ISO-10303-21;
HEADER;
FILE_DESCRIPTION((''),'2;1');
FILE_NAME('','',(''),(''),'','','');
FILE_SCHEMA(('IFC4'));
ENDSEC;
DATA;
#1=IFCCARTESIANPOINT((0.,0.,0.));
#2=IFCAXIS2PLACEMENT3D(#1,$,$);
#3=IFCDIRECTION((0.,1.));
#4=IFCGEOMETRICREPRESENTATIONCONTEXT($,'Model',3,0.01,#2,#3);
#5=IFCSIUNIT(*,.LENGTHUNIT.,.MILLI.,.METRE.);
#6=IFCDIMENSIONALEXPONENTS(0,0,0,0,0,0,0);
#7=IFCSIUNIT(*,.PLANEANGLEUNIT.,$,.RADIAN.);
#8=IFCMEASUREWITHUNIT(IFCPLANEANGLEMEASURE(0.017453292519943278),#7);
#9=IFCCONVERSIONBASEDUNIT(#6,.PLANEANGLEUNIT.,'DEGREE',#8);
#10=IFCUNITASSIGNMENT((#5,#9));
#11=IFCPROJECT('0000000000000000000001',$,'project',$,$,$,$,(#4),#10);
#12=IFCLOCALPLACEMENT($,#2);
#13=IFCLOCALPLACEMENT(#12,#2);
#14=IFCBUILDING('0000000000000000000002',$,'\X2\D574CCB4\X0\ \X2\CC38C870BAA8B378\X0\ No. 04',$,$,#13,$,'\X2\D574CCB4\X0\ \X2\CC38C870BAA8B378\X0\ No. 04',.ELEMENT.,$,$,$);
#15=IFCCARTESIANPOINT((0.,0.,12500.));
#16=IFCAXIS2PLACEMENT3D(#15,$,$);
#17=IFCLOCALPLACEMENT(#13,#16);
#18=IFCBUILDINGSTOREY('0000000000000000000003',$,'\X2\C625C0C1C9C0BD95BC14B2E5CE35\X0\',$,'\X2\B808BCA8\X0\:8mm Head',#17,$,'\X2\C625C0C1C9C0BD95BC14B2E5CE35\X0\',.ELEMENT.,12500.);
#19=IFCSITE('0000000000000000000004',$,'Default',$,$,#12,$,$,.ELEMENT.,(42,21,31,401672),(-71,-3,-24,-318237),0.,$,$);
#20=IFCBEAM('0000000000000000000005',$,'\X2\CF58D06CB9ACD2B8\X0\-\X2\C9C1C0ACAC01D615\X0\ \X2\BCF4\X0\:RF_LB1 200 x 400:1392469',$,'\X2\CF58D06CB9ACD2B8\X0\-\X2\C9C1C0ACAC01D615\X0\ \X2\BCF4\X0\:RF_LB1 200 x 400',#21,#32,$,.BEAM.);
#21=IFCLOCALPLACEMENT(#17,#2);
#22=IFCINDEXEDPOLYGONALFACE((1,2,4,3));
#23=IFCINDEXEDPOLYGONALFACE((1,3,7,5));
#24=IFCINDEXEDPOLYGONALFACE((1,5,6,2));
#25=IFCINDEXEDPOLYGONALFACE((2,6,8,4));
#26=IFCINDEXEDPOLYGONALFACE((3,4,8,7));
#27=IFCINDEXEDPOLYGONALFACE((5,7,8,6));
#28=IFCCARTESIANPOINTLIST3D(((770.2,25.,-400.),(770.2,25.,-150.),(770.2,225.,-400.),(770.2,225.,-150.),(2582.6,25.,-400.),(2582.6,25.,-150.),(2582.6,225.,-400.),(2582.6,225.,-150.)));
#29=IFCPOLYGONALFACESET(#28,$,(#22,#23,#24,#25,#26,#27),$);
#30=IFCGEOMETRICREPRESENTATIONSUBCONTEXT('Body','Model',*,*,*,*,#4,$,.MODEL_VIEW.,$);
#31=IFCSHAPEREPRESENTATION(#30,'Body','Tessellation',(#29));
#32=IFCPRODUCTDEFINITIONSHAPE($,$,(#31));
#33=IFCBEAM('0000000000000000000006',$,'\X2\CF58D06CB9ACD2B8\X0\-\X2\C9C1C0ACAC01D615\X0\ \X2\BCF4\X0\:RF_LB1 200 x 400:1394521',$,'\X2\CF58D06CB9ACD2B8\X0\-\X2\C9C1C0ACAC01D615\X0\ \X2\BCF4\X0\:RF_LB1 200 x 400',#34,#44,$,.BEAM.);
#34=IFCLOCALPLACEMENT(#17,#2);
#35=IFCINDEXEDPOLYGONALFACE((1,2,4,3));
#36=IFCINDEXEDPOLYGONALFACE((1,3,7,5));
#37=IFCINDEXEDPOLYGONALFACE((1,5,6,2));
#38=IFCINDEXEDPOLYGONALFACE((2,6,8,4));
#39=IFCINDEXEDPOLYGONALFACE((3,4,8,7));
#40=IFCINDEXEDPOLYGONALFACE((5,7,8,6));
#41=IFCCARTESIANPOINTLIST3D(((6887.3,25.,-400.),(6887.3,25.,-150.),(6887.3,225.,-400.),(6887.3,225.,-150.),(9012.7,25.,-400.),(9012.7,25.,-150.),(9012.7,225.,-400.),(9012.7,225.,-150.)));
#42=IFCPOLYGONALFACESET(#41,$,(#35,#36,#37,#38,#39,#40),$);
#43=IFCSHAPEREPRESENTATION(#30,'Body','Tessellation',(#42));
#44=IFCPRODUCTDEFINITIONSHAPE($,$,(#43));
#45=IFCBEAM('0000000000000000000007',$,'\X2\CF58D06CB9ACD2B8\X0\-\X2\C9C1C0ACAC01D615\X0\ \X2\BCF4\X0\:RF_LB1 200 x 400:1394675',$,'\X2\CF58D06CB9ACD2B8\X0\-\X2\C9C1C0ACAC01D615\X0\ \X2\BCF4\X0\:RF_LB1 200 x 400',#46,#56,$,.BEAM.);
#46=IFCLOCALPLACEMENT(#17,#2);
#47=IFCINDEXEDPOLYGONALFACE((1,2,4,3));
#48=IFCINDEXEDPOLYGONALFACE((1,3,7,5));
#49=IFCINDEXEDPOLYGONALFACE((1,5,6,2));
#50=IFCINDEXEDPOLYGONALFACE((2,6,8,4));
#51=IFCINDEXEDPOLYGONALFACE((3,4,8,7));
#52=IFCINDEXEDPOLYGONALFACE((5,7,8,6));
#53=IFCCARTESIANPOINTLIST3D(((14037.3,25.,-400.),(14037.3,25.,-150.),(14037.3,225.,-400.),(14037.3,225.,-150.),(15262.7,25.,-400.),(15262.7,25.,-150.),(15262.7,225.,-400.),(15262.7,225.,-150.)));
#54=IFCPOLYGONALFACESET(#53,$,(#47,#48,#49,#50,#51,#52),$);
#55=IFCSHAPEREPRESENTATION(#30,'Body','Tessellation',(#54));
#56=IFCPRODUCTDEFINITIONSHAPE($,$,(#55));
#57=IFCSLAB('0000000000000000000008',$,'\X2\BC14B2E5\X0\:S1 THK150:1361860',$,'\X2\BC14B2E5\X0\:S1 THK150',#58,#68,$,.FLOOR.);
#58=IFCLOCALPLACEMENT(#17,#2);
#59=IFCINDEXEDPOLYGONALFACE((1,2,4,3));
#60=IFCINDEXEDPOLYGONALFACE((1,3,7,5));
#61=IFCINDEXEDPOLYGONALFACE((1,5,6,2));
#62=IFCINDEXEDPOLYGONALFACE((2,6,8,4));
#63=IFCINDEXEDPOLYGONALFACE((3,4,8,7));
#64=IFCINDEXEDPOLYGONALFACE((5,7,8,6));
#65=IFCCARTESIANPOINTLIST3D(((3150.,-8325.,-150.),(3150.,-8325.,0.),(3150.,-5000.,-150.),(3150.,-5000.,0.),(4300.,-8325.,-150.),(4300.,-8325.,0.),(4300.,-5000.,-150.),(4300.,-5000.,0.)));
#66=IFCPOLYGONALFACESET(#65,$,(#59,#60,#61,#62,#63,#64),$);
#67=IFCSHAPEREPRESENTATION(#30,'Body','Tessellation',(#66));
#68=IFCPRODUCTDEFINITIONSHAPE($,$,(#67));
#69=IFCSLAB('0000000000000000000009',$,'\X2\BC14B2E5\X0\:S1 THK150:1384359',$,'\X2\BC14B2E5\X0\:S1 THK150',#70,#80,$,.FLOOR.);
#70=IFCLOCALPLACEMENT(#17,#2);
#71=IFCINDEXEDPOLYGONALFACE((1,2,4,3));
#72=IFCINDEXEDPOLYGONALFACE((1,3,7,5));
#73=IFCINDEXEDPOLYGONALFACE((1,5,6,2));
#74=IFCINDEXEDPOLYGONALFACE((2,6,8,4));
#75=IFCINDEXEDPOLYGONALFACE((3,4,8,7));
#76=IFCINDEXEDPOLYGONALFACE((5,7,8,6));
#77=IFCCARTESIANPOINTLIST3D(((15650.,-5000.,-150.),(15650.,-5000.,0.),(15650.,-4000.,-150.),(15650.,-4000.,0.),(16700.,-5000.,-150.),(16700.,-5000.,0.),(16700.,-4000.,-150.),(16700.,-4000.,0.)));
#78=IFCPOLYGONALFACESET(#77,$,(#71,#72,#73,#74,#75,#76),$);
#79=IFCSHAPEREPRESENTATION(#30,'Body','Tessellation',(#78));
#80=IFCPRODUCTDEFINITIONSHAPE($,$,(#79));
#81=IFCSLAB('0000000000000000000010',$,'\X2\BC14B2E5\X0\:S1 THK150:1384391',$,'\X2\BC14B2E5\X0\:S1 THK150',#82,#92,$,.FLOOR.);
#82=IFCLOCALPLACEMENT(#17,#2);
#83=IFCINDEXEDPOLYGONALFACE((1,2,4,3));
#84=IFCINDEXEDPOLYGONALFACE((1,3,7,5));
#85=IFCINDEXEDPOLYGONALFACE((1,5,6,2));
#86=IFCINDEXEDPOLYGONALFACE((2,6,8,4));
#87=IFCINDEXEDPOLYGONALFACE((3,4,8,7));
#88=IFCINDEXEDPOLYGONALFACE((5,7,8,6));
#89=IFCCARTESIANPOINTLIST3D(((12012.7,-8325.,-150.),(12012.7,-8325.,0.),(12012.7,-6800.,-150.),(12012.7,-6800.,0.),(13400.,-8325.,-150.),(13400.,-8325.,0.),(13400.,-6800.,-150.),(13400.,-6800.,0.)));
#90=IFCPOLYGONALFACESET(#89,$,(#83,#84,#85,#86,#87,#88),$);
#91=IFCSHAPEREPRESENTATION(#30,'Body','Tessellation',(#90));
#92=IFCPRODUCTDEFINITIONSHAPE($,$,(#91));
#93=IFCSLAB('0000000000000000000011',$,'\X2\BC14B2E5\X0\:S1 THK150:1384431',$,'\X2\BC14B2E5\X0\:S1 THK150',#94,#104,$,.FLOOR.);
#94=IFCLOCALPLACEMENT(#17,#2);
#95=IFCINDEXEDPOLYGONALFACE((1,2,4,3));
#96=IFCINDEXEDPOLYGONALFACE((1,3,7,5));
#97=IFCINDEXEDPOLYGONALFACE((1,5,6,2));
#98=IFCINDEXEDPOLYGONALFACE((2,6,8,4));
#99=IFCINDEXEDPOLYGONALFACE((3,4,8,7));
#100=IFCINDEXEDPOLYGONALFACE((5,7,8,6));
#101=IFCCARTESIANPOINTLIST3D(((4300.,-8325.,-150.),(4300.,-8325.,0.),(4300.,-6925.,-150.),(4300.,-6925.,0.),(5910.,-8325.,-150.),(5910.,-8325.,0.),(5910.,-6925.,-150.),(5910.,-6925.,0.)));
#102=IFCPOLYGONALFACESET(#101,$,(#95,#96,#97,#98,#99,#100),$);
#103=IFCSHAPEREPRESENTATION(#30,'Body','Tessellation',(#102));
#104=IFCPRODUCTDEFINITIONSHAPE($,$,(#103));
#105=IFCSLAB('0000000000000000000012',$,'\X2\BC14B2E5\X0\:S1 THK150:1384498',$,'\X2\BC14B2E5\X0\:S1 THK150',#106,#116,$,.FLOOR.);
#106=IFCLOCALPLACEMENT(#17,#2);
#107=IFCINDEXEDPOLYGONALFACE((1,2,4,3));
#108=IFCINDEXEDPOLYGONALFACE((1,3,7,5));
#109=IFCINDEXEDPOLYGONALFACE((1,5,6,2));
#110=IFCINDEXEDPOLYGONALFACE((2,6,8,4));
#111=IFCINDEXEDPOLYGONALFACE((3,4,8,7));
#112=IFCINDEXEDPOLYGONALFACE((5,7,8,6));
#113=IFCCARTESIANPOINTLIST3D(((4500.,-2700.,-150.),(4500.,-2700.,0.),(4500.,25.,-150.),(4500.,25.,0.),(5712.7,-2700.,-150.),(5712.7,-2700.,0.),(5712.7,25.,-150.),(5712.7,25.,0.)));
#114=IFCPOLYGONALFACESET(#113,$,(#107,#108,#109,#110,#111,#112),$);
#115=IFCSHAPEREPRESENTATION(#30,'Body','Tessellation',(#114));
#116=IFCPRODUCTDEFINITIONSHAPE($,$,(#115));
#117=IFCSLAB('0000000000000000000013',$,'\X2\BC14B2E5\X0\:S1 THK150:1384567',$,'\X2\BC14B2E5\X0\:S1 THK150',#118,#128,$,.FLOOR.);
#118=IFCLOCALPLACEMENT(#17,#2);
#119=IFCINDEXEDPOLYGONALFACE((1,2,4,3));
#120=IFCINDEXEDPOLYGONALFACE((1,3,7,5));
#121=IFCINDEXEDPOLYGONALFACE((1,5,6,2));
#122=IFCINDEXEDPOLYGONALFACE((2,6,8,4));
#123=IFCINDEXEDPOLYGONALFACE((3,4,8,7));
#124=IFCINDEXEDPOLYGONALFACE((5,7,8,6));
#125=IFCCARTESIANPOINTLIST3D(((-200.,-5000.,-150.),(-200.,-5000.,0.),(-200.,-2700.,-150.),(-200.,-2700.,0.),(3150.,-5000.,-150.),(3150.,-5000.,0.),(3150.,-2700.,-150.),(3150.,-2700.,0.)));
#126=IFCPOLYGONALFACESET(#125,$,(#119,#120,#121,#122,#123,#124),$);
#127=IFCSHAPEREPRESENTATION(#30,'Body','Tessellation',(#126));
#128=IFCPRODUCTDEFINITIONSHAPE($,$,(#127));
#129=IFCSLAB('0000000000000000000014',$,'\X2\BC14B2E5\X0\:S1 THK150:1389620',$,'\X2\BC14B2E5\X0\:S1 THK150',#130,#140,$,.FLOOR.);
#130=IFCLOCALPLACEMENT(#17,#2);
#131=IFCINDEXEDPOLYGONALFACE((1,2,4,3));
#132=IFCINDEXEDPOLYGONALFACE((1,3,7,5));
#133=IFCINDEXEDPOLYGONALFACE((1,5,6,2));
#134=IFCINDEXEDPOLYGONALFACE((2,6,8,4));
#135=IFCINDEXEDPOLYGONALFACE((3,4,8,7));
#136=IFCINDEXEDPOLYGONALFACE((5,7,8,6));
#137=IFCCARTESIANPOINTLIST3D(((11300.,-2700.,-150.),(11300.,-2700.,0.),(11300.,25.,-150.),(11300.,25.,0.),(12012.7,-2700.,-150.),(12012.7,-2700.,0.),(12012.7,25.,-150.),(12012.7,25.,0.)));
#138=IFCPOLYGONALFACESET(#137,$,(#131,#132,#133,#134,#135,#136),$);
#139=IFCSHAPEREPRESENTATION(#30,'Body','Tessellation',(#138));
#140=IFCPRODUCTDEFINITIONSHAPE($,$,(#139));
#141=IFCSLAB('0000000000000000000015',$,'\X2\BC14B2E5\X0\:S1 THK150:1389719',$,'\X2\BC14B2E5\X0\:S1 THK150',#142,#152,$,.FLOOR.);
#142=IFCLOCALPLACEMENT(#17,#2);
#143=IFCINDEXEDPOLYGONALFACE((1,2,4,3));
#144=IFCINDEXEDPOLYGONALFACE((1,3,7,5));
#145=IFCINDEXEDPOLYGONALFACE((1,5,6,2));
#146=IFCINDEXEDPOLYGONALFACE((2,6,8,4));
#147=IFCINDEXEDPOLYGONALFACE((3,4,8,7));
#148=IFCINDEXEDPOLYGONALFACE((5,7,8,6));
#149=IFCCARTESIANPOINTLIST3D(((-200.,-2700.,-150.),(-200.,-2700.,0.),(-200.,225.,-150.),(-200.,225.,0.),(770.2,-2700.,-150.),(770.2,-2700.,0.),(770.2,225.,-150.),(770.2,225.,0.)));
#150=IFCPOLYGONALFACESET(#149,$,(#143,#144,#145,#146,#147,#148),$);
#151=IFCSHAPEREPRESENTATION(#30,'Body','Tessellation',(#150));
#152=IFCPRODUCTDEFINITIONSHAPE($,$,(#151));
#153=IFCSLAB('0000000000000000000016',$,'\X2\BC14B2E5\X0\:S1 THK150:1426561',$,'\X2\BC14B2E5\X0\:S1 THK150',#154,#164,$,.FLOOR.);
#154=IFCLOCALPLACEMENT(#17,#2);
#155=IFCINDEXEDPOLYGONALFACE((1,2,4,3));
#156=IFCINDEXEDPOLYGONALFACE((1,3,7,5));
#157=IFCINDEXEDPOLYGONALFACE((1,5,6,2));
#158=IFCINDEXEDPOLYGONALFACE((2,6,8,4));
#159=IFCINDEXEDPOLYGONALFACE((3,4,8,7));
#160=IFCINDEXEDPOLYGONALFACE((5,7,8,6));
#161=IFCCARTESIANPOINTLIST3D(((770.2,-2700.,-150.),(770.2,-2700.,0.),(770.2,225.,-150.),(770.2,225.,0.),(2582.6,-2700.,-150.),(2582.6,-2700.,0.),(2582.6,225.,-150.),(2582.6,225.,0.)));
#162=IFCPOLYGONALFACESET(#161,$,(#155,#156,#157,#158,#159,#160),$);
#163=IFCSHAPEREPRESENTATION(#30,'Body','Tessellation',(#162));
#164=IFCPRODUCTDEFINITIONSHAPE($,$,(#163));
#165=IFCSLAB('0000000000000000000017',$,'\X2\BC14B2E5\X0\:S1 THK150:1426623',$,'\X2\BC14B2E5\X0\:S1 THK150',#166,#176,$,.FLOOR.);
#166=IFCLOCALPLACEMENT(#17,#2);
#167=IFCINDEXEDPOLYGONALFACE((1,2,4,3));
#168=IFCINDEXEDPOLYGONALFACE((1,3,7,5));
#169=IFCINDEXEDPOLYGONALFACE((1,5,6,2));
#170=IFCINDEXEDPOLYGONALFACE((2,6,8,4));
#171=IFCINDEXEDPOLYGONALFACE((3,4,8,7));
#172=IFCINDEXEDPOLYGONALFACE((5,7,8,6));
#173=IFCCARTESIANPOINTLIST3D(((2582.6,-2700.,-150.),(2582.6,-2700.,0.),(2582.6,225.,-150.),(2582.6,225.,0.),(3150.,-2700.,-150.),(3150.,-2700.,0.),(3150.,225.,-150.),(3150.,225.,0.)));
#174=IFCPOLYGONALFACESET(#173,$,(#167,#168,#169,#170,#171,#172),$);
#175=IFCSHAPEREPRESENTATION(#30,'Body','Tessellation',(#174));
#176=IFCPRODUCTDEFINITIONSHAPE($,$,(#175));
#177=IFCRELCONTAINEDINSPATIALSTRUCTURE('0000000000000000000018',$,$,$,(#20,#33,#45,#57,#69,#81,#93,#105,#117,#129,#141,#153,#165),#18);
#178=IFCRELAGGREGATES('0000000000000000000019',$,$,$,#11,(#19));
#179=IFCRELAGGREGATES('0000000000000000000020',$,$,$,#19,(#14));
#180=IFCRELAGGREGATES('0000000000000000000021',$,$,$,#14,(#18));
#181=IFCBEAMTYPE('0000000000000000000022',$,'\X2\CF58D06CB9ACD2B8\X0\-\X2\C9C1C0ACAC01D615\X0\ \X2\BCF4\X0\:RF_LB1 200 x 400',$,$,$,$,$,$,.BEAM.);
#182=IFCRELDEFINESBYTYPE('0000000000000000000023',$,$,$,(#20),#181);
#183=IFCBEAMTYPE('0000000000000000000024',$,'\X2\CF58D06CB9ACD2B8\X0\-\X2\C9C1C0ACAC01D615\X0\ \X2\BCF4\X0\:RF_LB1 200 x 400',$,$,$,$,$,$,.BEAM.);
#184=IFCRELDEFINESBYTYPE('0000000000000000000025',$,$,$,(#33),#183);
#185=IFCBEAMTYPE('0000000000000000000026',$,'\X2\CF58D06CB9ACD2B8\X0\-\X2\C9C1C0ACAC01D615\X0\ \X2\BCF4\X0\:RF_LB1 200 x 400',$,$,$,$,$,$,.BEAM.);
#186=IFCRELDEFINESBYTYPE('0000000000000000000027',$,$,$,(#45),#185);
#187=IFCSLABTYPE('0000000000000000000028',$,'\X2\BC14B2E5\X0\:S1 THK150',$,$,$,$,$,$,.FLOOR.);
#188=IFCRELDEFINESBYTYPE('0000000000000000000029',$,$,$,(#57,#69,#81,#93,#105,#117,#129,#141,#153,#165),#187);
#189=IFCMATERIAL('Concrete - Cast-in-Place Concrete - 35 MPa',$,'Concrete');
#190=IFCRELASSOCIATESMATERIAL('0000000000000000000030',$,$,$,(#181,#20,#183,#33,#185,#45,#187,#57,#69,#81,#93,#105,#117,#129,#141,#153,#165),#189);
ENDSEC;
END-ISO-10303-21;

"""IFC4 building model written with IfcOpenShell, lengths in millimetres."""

from ifc_helpers import new_model, entity, si_unit, converted_unit, direction, frame, origin, place, context, subcontext, project, spatial, indexed_curve, outline, extrude, source, transform, mapped, material, type_object, type_shapes, element, save


model = new_model("IFC4")

# Units and contexts
model_context = context("Model", 3, precision=0.01, world=origin(), true_north=direction((0.0, 1.0)))
body_context = subcontext(model_context, "Body", "Model", "MODEL_VIEW")
ifc_project = project(units=[si_unit("LENGTHUNIT", "METRE", prefix="MILLI"), converted_unit("PLANEANGLEUNIT", "DEGREE", entity("IfcPlaneAngleMeasure", 0.017453292519943278), si_unit("PLANEANGLEUNIT", "RADIAN"), dimensions=[0, 0, 0, 0, 0, 0, 0])], contexts=[model_context])

# Site, building, storey
site_placement = place(None, origin())
site = spatial("IfcSite", under=ifc_project, at=site_placement, Name="Default", CompositionType="ELEMENT", RefLatitude=(42, 21, 31, 401672), RefLongitude=(-71, -3, -24, -318237), RefElevation=0.0)
building_placement = place(site_placement, origin())
building = spatial("IfcBuilding", under=site, at=building_placement, Name="해체 참조모델 No. 04", LongName="해체 참조모델 No. 04", CompositionType="ELEMENT")
storey_placement = place(building_placement, frame((0.0, 0.0, 12500.0)))
storey = spatial("IfcBuildingStorey", under=building, at=storey_placement, Name="옥상지붕바닥층", ObjectType="레벨:8mm Head", LongName="옥상지붕바닥층", CompositionType="ELEMENT", Elevation=12500.0)

# Beams
ifc_material_1 = material(Name="Concrete - Cast-in-Place Concrete - 35 MPa", Category="Concrete")
beam_type_1 = type_object("IfcBeamType", Name="콘크리트-직사각형 보:RF_LB1 200 x 400", PredefinedType="BEAM", material=ifc_material_1)
shared_shape_1 = source(origin(), body_context, "Body", "SweptSolid", [
    extrude(outline(indexed_curve([(-125.0, -100.0), (125.0, -100.0), (125.0, 100.0), (-125.0, 100.0), (-125.0, -100.0)], self_intersect=False)), frame((770.2, 125.0, 12225.0), z_axis=(1.0, 0.0, 0.0), x_axis=(0.0, 0.0, -1.0)), (0.0, 0.0, 1.0), 1812.4),
])
type_shapes(beam_type_1, [shared_shape_1])
beam_1_placement = place(storey_placement, frame((0.0, 0.0, -12500.0)))
element("IfcBeam", 1, at=beam_1_placement, inside=storey, type_object=beam_type_1, material=ifc_material_1, Name="콘크리트-직사각형 보:RF_LB1 200 x 400:1392469", ObjectType="콘크리트-직사각형 보:RF_LB1 200 x 400", PredefinedType="BEAM", context=body_context, shape_type="MappedRepresentation", body=[
    mapped(shared_shape_1, transform((0.0, 0.0, 0.0), scale=1.0)),
])
beam_type_2 = type_object("IfcBeamType", Name="콘크리트-직사각형 보:RF_LB1 200 x 400", PredefinedType="BEAM", material=ifc_material_1)
shared_shape_2 = source(origin(), body_context, "Body", "SweptSolid", [
    extrude(outline(indexed_curve([(-125.0, -100.0), (125.0, -100.0), (125.0, 100.0), (-125.0, 100.0), (-125.0, -100.0)], self_intersect=False)), frame((6887.3, 125.0, 12225.0), z_axis=(1.0, 0.0, 0.0), x_axis=(0.0, 0.0, -1.0)), (0.0, 0.0, 1.0), 2125.4),
])
type_shapes(beam_type_2, [shared_shape_2])
beam_2_placement = place(storey_placement, frame((0.0, 0.0, -12500.0)))
element("IfcBeam", 2, at=beam_2_placement, inside=storey, type_object=beam_type_2, material=ifc_material_1, Name="콘크리트-직사각형 보:RF_LB1 200 x 400:1394521", ObjectType="콘크리트-직사각형 보:RF_LB1 200 x 400", PredefinedType="BEAM", context=body_context, shape_type="MappedRepresentation", body=[
    mapped(shared_shape_2, transform((0.0, 0.0, 0.0), scale=1.0)),
])
beam_type_3 = type_object("IfcBeamType", Name="콘크리트-직사각형 보:RF_LB1 200 x 400", PredefinedType="BEAM", material=ifc_material_1)
shared_shape_3 = source(origin(), body_context, "Body", "SweptSolid", [
    extrude(outline(indexed_curve([(-125.0, -100.0), (125.0, -100.0), (125.0, 100.0), (-125.0, 100.0), (-125.0, -100.0)], self_intersect=False)), frame((14037.3, 125.0, 12225.0), z_axis=(1.0, 0.0, 0.0), x_axis=(0.0, 0.0, -1.0)), (0.0, 0.0, 1.0), 1225.4),
])
type_shapes(beam_type_3, [shared_shape_3])
beam_3_placement = place(storey_placement, frame((0.0, 0.0, -12500.0)))
element("IfcBeam", 3, at=beam_3_placement, inside=storey, type_object=beam_type_3, material=ifc_material_1, Name="콘크리트-직사각형 보:RF_LB1 200 x 400:1394675", ObjectType="콘크리트-직사각형 보:RF_LB1 200 x 400", PredefinedType="BEAM", context=body_context, shape_type="MappedRepresentation", body=[
    mapped(shared_shape_3, transform((0.0, 0.0, 0.0), scale=1.0)),
])

# Slabs
slab_type_1 = type_object("IfcSlabType", Name="바닥:S1 THK150", PredefinedType="FLOOR", material=ifc_material_1)
slab_1_placement = place(storey_placement, origin())
element("IfcSlab", 4, at=slab_1_placement, inside=storey, type_object=slab_type_1, material=ifc_material_1, Name="바닥:S1 THK150:1361860", ObjectType="바닥:S1 THK150", PredefinedType="FLOOR", context=body_context, shape_type="SweptSolid", body=[
    extrude(outline(indexed_curve([(-1662.5, -575.0), (1662.5, -575.0), (1662.5, 575.0), (-1662.5, 575.0), (-1662.5, -575.0)], self_intersect=False)), frame((3725.0, -6662.5, 0.0), z_axis=(0.0, 0.0, -1.0), x_axis=(0.0, 1.0, 0.0)), (0.0, 0.0, 1.0), 150.0),
])
slab_2_placement = place(storey_placement, origin())
element("IfcSlab", 5, at=slab_2_placement, inside=storey, type_object=slab_type_1, material=ifc_material_1, Name="바닥:S1 THK150:1384359", ObjectType="바닥:S1 THK150", PredefinedType="FLOOR", context=body_context, shape_type="SweptSolid", body=[
    extrude(outline(indexed_curve([(-500.0, -525.0), (500.0, -525.0), (500.0, 525.0), (-500.0, 525.0), (-500.0, -525.0)], self_intersect=False)), frame((16175.0, -4500.0, 0.0), z_axis=(0.0, 0.0, -1.0), x_axis=(0.0, 1.0, 0.0)), (0.0, 0.0, 1.0), 150.0),
])
slab_3_placement = place(storey_placement, origin())
element("IfcSlab", 6, at=slab_3_placement, inside=storey, type_object=slab_type_1, material=ifc_material_1, Name="바닥:S1 THK150:1384391", ObjectType="바닥:S1 THK150", PredefinedType="FLOOR", context=body_context, shape_type="SweptSolid", body=[
    extrude(outline(indexed_curve([(-762.5, -693.6), (762.5, -693.6), (762.5, 693.6), (-762.5, 693.6), (-762.5, -693.6)], self_intersect=False)), frame((12706.4, -7562.5, 0.0), z_axis=(0.0, 0.0, -1.0), x_axis=(0.0, 1.0, 0.0)), (0.0, 0.0, 1.0), 150.0),
])
slab_4_placement = place(storey_placement, origin())
element("IfcSlab", 7, at=slab_4_placement, inside=storey, type_object=slab_type_1, material=ifc_material_1, Name="바닥:S1 THK150:1384431", ObjectType="바닥:S1 THK150", PredefinedType="FLOOR", context=body_context, shape_type="SweptSolid", body=[
    extrude(outline(indexed_curve([(-700.0, -805.0), (700.0, -805.0), (700.0, 805.0), (-700.0, 805.0), (-700.0, -805.0)], self_intersect=False)), frame((5105.0, -7625.0, 0.0), z_axis=(0.0, 0.0, -1.0), x_axis=(0.0, 1.0, 0.0)), (0.0, 0.0, 1.0), 150.0),
])
slab_5_placement = place(storey_placement, origin())
element("IfcSlab", 8, at=slab_5_placement, inside=storey, type_object=slab_type_1, material=ifc_material_1, Name="바닥:S1 THK150:1384498", ObjectType="바닥:S1 THK150", PredefinedType="FLOOR", context=body_context, shape_type="SweptSolid", body=[
    extrude(outline(indexed_curve([(-1362.5, -606.4), (1362.5, -606.4), (1362.5, 606.4), (-1362.5, 606.4), (-1362.5, -606.4)], self_intersect=False)), frame((5106.4, -1337.5, 0.0), z_axis=(0.0, 0.0, -1.0), x_axis=(0.0, 1.0, 0.0)), (0.0, 0.0, 1.0), 150.0),
])
slab_6_placement = place(storey_placement, origin())
element("IfcSlab", 9, at=slab_6_placement, inside=storey, type_object=slab_type_1, material=ifc_material_1, Name="바닥:S1 THK150:1384567", ObjectType="바닥:S1 THK150", PredefinedType="FLOOR", context=body_context, shape_type="SweptSolid", body=[
    extrude(outline(indexed_curve([(-1150.0, -1675.0), (1150.0, -1675.0), (1150.0, 1675.0), (-1150.0, 1675.0), (-1150.0, -1675.0)], self_intersect=False)), frame((1475.0, -3850.0, 0.0), z_axis=(0.0, 0.0, -1.0), x_axis=(0.0, 1.0, 0.0)), (0.0, 0.0, 1.0), 150.0),
])
slab_7_placement = place(storey_placement, origin())
element("IfcSlab", 10, at=slab_7_placement, inside=storey, type_object=slab_type_1, material=ifc_material_1, Name="바닥:S1 THK150:1389620", ObjectType="바닥:S1 THK150", PredefinedType="FLOOR", context=body_context, shape_type="SweptSolid", body=[
    extrude(outline(indexed_curve([(-1362.5, -356.4), (1362.5, -356.4), (1362.5, 356.4), (-1362.5, 356.4), (-1362.5, -356.4)], self_intersect=False)), frame((11656.4, -1337.5, 0.0), z_axis=(0.0, 0.0, -1.0), x_axis=(0.0, 1.0, 0.0)), (0.0, 0.0, 1.0), 150.0),
])
slab_8_placement = place(storey_placement, origin())
element("IfcSlab", 11, at=slab_8_placement, inside=storey, type_object=slab_type_1, material=ifc_material_1, Name="바닥:S1 THK150:1389719", ObjectType="바닥:S1 THK150", PredefinedType="FLOOR", context=body_context, shape_type="SweptSolid", body=[
    extrude(outline(indexed_curve([(-1462.5, -485.1), (1462.5, -485.1), (1462.5, 485.1), (-1462.5, 485.1), (-1462.5, -485.1)], self_intersect=False)), frame((285.1, -1237.5, 0.0), z_axis=(0.0, 0.0, -1.0), x_axis=(0.0, 1.0, 0.0)), (0.0, 0.0, 1.0), 150.0),
])
slab_9_placement = place(storey_placement, origin())
element("IfcSlab", 12, at=slab_9_placement, inside=storey, type_object=slab_type_1, material=ifc_material_1, Name="바닥:S1 THK150:1426561", ObjectType="바닥:S1 THK150", PredefinedType="FLOOR", context=body_context, shape_type="SweptSolid", body=[
    extrude(outline(indexed_curve([(-1462.5, -906.2), (1462.5, -906.2), (1462.5, 906.2), (-1462.5, 906.2), (-1462.5, -906.2)], self_intersect=False)), frame((1676.4, -1237.5, 0.0), z_axis=(0.0, 0.0, -1.0), x_axis=(0.0, 1.0, 0.0)), (0.0, 0.0, 1.0), 150.0),
])
slab_10_placement = place(storey_placement, origin())
element("IfcSlab", 13, at=slab_10_placement, inside=storey, type_object=slab_type_1, material=ifc_material_1, Name="바닥:S1 THK150:1426623", ObjectType="바닥:S1 THK150", PredefinedType="FLOOR", context=body_context, shape_type="SweptSolid", body=[
    extrude(outline(indexed_curve([(-1462.5, -283.7), (1462.5, -283.7), (1462.5, 283.7), (-1462.5, 283.7), (-1462.5, -283.7)], self_intersect=False)), frame((2866.3, -1237.5, 0.0), z_axis=(0.0, 0.0, -1.0), x_axis=(0.0, 1.0, 0.0)), (0.0, 0.0, 1.0), 150.0),
])

save(model, "model.ifc")
